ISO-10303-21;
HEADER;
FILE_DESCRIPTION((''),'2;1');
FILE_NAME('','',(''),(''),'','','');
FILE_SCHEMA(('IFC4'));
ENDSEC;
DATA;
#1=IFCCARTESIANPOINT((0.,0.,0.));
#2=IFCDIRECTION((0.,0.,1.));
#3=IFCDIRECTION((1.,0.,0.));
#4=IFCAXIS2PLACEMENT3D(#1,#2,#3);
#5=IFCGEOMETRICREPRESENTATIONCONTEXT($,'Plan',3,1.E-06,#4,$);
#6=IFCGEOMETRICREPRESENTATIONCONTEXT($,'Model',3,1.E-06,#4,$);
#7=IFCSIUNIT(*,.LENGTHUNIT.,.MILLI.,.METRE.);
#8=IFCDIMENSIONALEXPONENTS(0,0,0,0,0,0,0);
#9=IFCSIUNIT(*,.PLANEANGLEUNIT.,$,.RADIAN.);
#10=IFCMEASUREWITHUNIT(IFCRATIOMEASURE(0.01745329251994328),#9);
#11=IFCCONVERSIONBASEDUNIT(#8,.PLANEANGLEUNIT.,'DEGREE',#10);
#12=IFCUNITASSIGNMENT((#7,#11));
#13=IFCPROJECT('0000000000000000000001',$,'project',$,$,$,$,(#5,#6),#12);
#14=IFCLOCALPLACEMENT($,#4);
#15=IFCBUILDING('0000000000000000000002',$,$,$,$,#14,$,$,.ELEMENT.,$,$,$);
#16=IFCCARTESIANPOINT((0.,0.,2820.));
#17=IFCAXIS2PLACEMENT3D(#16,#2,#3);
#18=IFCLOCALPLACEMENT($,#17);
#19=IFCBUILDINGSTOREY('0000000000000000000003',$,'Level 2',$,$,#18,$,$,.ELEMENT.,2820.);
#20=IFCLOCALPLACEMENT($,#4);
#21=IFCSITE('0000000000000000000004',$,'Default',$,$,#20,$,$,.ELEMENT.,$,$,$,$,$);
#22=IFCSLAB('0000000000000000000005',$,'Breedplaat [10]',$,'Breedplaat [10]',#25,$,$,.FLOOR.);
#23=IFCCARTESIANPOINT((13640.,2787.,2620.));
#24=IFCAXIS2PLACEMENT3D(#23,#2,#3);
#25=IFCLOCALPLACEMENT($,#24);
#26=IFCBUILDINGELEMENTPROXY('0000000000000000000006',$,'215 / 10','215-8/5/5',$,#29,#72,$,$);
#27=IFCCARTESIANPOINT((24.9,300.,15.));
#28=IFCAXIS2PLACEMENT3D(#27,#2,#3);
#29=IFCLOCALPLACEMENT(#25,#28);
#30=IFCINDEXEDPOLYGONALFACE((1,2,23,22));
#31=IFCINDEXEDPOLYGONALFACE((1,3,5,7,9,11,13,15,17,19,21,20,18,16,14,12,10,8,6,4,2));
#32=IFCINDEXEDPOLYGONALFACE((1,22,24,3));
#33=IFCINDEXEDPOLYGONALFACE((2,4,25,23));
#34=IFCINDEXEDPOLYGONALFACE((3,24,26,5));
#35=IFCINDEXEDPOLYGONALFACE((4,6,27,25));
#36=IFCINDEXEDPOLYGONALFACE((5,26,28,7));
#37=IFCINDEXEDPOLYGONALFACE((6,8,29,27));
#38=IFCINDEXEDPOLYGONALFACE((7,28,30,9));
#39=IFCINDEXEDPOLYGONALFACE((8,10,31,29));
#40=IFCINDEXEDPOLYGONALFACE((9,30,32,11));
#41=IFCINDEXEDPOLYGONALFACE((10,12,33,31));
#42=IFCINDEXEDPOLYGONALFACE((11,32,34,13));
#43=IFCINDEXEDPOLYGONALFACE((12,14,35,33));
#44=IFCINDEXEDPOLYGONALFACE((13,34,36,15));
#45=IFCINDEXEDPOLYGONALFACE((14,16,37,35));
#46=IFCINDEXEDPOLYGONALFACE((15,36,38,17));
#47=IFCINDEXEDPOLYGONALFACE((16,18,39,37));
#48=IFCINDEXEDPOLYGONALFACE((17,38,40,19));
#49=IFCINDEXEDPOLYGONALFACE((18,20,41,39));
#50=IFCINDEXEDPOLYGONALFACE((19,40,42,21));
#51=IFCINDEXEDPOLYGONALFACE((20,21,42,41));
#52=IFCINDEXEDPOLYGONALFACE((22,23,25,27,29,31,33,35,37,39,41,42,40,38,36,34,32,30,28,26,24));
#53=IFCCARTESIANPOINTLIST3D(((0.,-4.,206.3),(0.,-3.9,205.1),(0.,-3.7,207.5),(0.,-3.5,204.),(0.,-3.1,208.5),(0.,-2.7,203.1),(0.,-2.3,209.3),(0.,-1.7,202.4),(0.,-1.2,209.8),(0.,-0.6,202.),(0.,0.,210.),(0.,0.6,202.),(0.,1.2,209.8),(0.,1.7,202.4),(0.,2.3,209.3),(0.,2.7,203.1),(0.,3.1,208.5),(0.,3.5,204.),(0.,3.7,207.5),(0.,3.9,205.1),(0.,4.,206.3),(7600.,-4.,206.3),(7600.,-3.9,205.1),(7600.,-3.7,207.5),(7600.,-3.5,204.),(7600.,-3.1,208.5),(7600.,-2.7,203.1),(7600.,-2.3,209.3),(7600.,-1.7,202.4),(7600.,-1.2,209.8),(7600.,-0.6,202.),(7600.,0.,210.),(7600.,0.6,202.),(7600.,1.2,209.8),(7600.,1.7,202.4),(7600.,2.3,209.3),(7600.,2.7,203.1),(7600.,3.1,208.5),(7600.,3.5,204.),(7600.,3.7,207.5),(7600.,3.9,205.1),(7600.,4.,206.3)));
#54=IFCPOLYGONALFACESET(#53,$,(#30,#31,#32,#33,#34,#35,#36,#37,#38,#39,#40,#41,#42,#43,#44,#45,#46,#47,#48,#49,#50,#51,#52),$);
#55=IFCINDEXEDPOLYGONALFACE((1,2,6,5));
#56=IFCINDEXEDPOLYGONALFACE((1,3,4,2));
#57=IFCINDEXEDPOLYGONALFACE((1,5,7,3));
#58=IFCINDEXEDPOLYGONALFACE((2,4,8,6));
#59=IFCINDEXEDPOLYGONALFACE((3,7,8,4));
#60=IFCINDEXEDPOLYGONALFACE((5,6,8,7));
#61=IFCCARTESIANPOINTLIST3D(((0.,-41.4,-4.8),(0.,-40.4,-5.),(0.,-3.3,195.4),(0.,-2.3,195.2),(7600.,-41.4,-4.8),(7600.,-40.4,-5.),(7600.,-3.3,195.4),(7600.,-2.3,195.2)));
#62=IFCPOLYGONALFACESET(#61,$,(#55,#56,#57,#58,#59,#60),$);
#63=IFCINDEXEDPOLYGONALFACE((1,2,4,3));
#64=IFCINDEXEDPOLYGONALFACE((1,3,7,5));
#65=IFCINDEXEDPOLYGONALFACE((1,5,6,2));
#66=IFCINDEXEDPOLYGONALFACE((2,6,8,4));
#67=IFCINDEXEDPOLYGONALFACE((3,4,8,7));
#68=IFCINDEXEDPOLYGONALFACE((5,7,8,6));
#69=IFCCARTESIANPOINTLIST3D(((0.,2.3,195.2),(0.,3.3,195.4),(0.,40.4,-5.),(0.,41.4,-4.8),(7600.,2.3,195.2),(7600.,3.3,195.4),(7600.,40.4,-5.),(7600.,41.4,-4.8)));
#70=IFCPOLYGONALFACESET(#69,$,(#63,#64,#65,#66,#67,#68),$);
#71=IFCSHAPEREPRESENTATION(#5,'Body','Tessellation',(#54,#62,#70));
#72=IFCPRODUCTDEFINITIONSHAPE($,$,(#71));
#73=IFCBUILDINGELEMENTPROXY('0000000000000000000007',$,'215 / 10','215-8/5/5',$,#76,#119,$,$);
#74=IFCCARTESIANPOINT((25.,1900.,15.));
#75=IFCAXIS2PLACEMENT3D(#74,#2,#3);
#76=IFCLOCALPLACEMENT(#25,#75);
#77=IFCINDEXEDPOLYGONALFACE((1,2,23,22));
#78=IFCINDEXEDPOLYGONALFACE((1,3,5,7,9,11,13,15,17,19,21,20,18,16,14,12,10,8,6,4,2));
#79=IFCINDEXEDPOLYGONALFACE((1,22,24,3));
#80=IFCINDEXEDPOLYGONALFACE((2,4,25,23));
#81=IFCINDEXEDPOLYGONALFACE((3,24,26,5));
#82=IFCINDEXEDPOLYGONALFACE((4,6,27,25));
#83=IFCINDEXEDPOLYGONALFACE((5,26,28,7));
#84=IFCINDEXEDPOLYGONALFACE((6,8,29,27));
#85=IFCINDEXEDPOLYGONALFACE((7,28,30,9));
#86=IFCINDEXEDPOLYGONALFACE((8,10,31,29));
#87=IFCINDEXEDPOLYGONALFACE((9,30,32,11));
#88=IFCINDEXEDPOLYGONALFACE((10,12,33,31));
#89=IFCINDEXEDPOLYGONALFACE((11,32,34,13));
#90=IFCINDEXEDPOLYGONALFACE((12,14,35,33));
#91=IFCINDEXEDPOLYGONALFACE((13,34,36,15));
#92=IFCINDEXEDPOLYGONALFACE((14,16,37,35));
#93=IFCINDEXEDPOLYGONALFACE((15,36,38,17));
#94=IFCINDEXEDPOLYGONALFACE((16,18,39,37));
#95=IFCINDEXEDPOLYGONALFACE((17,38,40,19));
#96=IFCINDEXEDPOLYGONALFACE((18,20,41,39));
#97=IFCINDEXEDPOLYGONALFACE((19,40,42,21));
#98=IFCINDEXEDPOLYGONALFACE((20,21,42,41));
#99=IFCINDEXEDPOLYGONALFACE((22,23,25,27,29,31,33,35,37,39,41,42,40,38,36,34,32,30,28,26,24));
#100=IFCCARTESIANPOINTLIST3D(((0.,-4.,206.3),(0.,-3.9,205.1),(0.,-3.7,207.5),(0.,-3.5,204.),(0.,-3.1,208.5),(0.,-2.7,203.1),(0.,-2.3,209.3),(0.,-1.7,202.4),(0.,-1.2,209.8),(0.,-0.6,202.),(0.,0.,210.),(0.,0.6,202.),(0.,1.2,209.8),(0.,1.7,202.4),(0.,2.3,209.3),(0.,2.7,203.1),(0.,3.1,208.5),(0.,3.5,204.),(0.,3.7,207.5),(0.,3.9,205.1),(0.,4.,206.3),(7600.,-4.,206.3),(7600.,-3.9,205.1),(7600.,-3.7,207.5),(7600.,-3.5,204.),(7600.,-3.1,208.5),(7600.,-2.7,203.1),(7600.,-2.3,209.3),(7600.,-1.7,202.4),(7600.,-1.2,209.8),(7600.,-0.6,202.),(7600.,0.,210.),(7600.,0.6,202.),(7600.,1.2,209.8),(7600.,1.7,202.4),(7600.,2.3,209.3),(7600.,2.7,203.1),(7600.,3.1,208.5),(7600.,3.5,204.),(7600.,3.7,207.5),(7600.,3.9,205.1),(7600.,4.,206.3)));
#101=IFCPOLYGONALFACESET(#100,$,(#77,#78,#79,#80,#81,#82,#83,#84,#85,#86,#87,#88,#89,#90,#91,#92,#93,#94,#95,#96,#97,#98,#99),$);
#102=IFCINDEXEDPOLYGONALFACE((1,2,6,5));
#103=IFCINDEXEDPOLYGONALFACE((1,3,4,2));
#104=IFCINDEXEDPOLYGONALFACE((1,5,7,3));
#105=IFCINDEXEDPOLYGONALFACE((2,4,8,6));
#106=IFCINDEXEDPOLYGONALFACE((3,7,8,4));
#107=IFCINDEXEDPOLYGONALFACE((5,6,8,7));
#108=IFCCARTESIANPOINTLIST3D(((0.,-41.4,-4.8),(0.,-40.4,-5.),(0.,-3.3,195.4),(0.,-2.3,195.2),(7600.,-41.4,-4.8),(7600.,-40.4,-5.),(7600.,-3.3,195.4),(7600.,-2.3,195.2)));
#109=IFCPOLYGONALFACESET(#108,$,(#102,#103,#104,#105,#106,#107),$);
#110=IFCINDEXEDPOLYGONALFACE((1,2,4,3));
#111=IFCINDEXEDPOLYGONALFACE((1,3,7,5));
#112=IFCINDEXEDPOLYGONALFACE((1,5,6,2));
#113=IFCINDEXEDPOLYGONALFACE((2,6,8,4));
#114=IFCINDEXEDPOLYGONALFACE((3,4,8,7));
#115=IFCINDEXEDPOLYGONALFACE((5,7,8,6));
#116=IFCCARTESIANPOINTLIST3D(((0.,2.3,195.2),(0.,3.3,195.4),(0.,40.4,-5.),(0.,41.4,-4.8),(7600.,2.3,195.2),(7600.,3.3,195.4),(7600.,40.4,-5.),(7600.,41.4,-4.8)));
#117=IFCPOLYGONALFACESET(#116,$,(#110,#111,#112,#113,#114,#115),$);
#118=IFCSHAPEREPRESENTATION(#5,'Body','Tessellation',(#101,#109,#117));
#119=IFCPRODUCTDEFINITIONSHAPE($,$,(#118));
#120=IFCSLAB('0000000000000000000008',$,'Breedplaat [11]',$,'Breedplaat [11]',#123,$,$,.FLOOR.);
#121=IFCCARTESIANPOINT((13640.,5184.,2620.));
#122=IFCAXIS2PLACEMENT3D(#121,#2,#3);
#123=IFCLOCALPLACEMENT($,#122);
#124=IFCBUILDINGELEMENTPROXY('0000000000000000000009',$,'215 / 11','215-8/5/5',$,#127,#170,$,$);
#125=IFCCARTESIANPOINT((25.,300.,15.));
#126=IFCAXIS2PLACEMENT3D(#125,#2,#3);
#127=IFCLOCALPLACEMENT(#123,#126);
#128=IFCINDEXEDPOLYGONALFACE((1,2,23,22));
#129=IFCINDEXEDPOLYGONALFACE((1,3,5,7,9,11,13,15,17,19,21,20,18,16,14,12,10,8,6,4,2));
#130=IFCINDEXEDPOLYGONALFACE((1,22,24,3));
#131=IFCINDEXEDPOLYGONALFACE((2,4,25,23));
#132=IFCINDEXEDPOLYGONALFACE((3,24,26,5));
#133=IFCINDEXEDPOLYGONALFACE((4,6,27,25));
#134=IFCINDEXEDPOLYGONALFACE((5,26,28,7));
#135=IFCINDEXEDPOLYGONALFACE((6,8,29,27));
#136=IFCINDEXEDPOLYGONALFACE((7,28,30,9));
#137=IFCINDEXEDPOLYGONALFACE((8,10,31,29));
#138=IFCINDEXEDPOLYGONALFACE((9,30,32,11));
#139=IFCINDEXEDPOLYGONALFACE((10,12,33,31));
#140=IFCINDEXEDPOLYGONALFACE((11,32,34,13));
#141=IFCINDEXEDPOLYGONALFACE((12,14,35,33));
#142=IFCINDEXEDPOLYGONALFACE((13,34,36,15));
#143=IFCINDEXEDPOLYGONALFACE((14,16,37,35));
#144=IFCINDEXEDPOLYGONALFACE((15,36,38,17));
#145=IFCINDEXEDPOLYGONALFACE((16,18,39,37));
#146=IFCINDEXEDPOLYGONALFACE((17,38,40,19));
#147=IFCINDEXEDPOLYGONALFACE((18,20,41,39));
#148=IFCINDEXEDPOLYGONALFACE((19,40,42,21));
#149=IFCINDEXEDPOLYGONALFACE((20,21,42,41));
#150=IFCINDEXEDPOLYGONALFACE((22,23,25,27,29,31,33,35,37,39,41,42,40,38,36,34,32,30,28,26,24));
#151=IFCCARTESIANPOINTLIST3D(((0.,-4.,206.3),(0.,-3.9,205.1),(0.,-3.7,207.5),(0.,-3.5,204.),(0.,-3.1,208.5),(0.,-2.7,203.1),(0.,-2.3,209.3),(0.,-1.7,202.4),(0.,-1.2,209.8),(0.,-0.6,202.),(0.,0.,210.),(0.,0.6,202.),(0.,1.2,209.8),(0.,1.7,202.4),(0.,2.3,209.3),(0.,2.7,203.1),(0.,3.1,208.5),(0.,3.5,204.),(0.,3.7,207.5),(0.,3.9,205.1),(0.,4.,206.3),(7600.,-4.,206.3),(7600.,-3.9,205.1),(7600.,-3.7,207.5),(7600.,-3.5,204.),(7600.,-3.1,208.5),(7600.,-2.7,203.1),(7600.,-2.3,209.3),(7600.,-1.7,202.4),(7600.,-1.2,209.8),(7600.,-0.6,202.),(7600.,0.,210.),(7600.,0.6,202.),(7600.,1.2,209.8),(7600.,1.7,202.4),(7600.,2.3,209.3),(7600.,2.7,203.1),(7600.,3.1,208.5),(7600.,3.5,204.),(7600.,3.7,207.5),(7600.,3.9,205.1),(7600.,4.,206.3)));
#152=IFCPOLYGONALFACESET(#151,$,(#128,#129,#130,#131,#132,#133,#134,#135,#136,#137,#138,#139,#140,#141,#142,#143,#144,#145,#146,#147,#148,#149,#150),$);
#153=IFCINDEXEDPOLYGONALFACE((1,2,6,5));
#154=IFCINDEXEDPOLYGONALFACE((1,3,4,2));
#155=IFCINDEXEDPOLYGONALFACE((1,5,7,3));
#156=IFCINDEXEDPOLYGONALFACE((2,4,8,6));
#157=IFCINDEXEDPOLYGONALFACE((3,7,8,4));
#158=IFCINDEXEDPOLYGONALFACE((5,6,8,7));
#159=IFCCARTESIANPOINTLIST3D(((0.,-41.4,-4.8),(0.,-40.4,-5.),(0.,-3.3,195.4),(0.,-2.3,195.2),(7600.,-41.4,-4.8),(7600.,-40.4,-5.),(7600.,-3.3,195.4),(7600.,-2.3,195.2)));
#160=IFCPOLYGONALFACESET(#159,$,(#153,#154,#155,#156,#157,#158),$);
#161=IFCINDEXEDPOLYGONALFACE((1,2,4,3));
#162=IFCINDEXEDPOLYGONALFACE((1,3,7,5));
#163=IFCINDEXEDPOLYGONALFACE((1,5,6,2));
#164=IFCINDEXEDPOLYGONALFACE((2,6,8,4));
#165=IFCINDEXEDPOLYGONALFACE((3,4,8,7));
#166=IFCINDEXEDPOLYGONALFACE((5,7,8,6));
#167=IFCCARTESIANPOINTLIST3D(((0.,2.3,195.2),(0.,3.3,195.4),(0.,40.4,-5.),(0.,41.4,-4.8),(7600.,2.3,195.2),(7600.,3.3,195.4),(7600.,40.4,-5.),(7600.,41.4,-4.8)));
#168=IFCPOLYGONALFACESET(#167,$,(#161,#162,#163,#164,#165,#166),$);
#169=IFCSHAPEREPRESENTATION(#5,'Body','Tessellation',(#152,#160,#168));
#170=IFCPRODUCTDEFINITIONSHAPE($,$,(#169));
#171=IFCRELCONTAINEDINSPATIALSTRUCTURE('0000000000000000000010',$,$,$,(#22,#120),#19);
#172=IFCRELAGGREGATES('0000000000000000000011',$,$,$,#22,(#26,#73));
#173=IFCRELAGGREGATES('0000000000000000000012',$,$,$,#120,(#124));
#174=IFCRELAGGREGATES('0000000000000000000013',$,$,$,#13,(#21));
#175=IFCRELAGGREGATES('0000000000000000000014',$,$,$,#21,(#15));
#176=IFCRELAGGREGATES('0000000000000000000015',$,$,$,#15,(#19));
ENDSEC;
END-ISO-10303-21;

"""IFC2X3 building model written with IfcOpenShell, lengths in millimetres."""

from ifc_helpers import new_model, entity, si_unit, converted_unit, frame, origin_with_axes, origin_2d_with_axis, place, context, project, spatial, rectangle, circle, extrude, element, aggregate, save


model = new_model("IFC2X3")

# Units and contexts
plan_context = context("Plan", 3, precision=1e-06, world=origin_with_axes())
model_context = context("Model", 3, precision=1e-06, world=origin_with_axes())
ifc_project = project(units=[si_unit("LENGTHUNIT", "METRE", prefix="MILLI"), converted_unit("PLANEANGLEUNIT", "DEGREE", entity("IfcRatioMeasure", 0.01745329251994328), si_unit("PLANEANGLEUNIT", "RADIAN"), dimensions=[0, 0, 0, 0, 0, 0, 0])], contexts=[plan_context, model_context])

# Site, building, storey
site_placement = place(None, origin_with_axes())
site = spatial("IfcSite", under=ifc_project, at=site_placement, Name="Default", CompositionType="ELEMENT")
building_placement = place(None, origin_with_axes())
building = spatial("IfcBuilding", under=site, at=building_placement, CompositionType="ELEMENT")
storey_placement = place(None, frame((0.0, 0.0, 2820.0), z_axis=(0.0, 0.0, 1.0), x_axis=(1.0, 0.0, 0.0)))
storey = spatial("IfcBuildingStorey", under=building, at=storey_placement, Name="Level 2", CompositionType="ELEMENT", Elevation=2820.0)

# Slabs, building element proxies
slab_1_placement = place(None, frame((13640.0, 2787.0, 2620.0), z_axis=(0.0, 0.0, 1.0), x_axis=(1.0, 0.0, 0.0)))
slab_1 = element("IfcSlab", 1, at=slab_1_placement, inside=storey, Name="Breedplaat [10]", ObjectType="Breedplaat [10]", PredefinedType="FLOOR")
proxy_1_placement = place(slab_1_placement, frame((24.9, 300.0, 15.0), z_axis=(0.0, 0.0, 1.0), x_axis=(1.0, 0.0, 0.0)))
proxy_1 = element("IfcBuildingElementProxy", 2, at=proxy_1_placement, Name="215 / 10", Description="215-8/5/5", context=plan_context, shape_type="SweptSolid", body=[
    extrude(circle(Radius=4.0, at=origin_2d_with_axis()), frame((0.0, 0.0, 206.0), z_axis=(1.0, 0.0, 0.0), x_axis=(0.0, 0.0, 1.0)), (0.0, 0.0, 1.0), 7600.0),
    extrude(rectangle(XDim=203.8, YDim=1.0, at=origin_2d_with_axis()), frame((0.0, -21.9, 95.2), z_axis=(1.0, 0.0, 0.0), x_axis=(0.0, 0.187112, 0.982339)), (0.0, 0.0, 1.0), 7600.0),
    extrude(rectangle(XDim=203.8, YDim=1.0, at=origin_2d_with_axis()), frame((0.0, 21.9, 95.2), z_axis=(1.0, 0.0, 0.0), x_axis=(0.0, -0.187112, 0.982339)), (0.0, 0.0, 1.0), 7600.0),
])
proxy_2_placement = place(slab_1_placement, frame((25.0, 1900.0, 15.0), z_axis=(0.0, 0.0, 1.0), x_axis=(1.0, 0.0, 0.0)))
proxy_2 = element("IfcBuildingElementProxy", 3, at=proxy_2_placement, Name="215 / 10", Description="215-8/5/5", context=plan_context, shape_type="SweptSolid", body=[
    extrude(circle(Radius=4.0, at=origin_2d_with_axis()), frame((0.0, 0.0, 206.0), z_axis=(1.0, 0.0, 0.0), x_axis=(0.0, 0.0, 1.0)), (0.0, 0.0, 1.0), 7600.0),
    extrude(rectangle(XDim=203.8, YDim=1.0, at=origin_2d_with_axis()), frame((0.0, -21.9, 95.2), z_axis=(1.0, 0.0, 0.0), x_axis=(0.0, 0.187112, 0.982339)), (0.0, 0.0, 1.0), 7600.0),
    extrude(rectangle(XDim=203.8, YDim=1.0, at=origin_2d_with_axis()), frame((0.0, 21.9, 95.2), z_axis=(1.0, 0.0, 0.0), x_axis=(0.0, -0.187112, 0.982339)), (0.0, 0.0, 1.0), 7600.0),
])
aggregate(slab_1, [proxy_1, proxy_2])
slab_2_placement = place(None, frame((13640.0, 5184.0, 2620.0), z_axis=(0.0, 0.0, 1.0), x_axis=(1.0, 0.0, 0.0)))
slab_2 = element("IfcSlab", 4, at=slab_2_placement, inside=storey, Name="Breedplaat [11]", ObjectType="Breedplaat [11]", PredefinedType="FLOOR")
proxy_3_placement = place(slab_2_placement, frame((25.0, 300.0, 15.0), z_axis=(0.0, 0.0, 1.0), x_axis=(1.0, 0.0, 0.0)))
proxy_3 = element("IfcBuildingElementProxy", 5, at=proxy_3_placement, Name="215 / 11", Description="215-8/5/5", context=plan_context, shape_type="SweptSolid", body=[
    extrude(circle(Radius=4.0, at=origin_2d_with_axis()), frame((0.0, 0.0, 206.0), z_axis=(1.0, 0.0, 0.0), x_axis=(0.0, 0.0, 1.0)), (0.0, 0.0, 1.0), 7600.0),
    extrude(rectangle(XDim=203.8, YDim=1.0, at=origin_2d_with_axis()), frame((0.0, -21.9, 95.2), z_axis=(1.0, 0.0, 0.0), x_axis=(0.0, 0.187112, 0.982339)), (0.0, 0.0, 1.0), 7600.0),
    extrude(rectangle(XDim=203.8, YDim=1.0, at=origin_2d_with_axis()), frame((0.0, 21.9, 95.2), z_axis=(1.0, 0.0, 0.0), x_axis=(0.0, -0.187112, 0.982339)), (0.0, 0.0, 1.0), 7600.0),
])
aggregate(slab_2, [proxy_3])

save(model, "model.ifc")
